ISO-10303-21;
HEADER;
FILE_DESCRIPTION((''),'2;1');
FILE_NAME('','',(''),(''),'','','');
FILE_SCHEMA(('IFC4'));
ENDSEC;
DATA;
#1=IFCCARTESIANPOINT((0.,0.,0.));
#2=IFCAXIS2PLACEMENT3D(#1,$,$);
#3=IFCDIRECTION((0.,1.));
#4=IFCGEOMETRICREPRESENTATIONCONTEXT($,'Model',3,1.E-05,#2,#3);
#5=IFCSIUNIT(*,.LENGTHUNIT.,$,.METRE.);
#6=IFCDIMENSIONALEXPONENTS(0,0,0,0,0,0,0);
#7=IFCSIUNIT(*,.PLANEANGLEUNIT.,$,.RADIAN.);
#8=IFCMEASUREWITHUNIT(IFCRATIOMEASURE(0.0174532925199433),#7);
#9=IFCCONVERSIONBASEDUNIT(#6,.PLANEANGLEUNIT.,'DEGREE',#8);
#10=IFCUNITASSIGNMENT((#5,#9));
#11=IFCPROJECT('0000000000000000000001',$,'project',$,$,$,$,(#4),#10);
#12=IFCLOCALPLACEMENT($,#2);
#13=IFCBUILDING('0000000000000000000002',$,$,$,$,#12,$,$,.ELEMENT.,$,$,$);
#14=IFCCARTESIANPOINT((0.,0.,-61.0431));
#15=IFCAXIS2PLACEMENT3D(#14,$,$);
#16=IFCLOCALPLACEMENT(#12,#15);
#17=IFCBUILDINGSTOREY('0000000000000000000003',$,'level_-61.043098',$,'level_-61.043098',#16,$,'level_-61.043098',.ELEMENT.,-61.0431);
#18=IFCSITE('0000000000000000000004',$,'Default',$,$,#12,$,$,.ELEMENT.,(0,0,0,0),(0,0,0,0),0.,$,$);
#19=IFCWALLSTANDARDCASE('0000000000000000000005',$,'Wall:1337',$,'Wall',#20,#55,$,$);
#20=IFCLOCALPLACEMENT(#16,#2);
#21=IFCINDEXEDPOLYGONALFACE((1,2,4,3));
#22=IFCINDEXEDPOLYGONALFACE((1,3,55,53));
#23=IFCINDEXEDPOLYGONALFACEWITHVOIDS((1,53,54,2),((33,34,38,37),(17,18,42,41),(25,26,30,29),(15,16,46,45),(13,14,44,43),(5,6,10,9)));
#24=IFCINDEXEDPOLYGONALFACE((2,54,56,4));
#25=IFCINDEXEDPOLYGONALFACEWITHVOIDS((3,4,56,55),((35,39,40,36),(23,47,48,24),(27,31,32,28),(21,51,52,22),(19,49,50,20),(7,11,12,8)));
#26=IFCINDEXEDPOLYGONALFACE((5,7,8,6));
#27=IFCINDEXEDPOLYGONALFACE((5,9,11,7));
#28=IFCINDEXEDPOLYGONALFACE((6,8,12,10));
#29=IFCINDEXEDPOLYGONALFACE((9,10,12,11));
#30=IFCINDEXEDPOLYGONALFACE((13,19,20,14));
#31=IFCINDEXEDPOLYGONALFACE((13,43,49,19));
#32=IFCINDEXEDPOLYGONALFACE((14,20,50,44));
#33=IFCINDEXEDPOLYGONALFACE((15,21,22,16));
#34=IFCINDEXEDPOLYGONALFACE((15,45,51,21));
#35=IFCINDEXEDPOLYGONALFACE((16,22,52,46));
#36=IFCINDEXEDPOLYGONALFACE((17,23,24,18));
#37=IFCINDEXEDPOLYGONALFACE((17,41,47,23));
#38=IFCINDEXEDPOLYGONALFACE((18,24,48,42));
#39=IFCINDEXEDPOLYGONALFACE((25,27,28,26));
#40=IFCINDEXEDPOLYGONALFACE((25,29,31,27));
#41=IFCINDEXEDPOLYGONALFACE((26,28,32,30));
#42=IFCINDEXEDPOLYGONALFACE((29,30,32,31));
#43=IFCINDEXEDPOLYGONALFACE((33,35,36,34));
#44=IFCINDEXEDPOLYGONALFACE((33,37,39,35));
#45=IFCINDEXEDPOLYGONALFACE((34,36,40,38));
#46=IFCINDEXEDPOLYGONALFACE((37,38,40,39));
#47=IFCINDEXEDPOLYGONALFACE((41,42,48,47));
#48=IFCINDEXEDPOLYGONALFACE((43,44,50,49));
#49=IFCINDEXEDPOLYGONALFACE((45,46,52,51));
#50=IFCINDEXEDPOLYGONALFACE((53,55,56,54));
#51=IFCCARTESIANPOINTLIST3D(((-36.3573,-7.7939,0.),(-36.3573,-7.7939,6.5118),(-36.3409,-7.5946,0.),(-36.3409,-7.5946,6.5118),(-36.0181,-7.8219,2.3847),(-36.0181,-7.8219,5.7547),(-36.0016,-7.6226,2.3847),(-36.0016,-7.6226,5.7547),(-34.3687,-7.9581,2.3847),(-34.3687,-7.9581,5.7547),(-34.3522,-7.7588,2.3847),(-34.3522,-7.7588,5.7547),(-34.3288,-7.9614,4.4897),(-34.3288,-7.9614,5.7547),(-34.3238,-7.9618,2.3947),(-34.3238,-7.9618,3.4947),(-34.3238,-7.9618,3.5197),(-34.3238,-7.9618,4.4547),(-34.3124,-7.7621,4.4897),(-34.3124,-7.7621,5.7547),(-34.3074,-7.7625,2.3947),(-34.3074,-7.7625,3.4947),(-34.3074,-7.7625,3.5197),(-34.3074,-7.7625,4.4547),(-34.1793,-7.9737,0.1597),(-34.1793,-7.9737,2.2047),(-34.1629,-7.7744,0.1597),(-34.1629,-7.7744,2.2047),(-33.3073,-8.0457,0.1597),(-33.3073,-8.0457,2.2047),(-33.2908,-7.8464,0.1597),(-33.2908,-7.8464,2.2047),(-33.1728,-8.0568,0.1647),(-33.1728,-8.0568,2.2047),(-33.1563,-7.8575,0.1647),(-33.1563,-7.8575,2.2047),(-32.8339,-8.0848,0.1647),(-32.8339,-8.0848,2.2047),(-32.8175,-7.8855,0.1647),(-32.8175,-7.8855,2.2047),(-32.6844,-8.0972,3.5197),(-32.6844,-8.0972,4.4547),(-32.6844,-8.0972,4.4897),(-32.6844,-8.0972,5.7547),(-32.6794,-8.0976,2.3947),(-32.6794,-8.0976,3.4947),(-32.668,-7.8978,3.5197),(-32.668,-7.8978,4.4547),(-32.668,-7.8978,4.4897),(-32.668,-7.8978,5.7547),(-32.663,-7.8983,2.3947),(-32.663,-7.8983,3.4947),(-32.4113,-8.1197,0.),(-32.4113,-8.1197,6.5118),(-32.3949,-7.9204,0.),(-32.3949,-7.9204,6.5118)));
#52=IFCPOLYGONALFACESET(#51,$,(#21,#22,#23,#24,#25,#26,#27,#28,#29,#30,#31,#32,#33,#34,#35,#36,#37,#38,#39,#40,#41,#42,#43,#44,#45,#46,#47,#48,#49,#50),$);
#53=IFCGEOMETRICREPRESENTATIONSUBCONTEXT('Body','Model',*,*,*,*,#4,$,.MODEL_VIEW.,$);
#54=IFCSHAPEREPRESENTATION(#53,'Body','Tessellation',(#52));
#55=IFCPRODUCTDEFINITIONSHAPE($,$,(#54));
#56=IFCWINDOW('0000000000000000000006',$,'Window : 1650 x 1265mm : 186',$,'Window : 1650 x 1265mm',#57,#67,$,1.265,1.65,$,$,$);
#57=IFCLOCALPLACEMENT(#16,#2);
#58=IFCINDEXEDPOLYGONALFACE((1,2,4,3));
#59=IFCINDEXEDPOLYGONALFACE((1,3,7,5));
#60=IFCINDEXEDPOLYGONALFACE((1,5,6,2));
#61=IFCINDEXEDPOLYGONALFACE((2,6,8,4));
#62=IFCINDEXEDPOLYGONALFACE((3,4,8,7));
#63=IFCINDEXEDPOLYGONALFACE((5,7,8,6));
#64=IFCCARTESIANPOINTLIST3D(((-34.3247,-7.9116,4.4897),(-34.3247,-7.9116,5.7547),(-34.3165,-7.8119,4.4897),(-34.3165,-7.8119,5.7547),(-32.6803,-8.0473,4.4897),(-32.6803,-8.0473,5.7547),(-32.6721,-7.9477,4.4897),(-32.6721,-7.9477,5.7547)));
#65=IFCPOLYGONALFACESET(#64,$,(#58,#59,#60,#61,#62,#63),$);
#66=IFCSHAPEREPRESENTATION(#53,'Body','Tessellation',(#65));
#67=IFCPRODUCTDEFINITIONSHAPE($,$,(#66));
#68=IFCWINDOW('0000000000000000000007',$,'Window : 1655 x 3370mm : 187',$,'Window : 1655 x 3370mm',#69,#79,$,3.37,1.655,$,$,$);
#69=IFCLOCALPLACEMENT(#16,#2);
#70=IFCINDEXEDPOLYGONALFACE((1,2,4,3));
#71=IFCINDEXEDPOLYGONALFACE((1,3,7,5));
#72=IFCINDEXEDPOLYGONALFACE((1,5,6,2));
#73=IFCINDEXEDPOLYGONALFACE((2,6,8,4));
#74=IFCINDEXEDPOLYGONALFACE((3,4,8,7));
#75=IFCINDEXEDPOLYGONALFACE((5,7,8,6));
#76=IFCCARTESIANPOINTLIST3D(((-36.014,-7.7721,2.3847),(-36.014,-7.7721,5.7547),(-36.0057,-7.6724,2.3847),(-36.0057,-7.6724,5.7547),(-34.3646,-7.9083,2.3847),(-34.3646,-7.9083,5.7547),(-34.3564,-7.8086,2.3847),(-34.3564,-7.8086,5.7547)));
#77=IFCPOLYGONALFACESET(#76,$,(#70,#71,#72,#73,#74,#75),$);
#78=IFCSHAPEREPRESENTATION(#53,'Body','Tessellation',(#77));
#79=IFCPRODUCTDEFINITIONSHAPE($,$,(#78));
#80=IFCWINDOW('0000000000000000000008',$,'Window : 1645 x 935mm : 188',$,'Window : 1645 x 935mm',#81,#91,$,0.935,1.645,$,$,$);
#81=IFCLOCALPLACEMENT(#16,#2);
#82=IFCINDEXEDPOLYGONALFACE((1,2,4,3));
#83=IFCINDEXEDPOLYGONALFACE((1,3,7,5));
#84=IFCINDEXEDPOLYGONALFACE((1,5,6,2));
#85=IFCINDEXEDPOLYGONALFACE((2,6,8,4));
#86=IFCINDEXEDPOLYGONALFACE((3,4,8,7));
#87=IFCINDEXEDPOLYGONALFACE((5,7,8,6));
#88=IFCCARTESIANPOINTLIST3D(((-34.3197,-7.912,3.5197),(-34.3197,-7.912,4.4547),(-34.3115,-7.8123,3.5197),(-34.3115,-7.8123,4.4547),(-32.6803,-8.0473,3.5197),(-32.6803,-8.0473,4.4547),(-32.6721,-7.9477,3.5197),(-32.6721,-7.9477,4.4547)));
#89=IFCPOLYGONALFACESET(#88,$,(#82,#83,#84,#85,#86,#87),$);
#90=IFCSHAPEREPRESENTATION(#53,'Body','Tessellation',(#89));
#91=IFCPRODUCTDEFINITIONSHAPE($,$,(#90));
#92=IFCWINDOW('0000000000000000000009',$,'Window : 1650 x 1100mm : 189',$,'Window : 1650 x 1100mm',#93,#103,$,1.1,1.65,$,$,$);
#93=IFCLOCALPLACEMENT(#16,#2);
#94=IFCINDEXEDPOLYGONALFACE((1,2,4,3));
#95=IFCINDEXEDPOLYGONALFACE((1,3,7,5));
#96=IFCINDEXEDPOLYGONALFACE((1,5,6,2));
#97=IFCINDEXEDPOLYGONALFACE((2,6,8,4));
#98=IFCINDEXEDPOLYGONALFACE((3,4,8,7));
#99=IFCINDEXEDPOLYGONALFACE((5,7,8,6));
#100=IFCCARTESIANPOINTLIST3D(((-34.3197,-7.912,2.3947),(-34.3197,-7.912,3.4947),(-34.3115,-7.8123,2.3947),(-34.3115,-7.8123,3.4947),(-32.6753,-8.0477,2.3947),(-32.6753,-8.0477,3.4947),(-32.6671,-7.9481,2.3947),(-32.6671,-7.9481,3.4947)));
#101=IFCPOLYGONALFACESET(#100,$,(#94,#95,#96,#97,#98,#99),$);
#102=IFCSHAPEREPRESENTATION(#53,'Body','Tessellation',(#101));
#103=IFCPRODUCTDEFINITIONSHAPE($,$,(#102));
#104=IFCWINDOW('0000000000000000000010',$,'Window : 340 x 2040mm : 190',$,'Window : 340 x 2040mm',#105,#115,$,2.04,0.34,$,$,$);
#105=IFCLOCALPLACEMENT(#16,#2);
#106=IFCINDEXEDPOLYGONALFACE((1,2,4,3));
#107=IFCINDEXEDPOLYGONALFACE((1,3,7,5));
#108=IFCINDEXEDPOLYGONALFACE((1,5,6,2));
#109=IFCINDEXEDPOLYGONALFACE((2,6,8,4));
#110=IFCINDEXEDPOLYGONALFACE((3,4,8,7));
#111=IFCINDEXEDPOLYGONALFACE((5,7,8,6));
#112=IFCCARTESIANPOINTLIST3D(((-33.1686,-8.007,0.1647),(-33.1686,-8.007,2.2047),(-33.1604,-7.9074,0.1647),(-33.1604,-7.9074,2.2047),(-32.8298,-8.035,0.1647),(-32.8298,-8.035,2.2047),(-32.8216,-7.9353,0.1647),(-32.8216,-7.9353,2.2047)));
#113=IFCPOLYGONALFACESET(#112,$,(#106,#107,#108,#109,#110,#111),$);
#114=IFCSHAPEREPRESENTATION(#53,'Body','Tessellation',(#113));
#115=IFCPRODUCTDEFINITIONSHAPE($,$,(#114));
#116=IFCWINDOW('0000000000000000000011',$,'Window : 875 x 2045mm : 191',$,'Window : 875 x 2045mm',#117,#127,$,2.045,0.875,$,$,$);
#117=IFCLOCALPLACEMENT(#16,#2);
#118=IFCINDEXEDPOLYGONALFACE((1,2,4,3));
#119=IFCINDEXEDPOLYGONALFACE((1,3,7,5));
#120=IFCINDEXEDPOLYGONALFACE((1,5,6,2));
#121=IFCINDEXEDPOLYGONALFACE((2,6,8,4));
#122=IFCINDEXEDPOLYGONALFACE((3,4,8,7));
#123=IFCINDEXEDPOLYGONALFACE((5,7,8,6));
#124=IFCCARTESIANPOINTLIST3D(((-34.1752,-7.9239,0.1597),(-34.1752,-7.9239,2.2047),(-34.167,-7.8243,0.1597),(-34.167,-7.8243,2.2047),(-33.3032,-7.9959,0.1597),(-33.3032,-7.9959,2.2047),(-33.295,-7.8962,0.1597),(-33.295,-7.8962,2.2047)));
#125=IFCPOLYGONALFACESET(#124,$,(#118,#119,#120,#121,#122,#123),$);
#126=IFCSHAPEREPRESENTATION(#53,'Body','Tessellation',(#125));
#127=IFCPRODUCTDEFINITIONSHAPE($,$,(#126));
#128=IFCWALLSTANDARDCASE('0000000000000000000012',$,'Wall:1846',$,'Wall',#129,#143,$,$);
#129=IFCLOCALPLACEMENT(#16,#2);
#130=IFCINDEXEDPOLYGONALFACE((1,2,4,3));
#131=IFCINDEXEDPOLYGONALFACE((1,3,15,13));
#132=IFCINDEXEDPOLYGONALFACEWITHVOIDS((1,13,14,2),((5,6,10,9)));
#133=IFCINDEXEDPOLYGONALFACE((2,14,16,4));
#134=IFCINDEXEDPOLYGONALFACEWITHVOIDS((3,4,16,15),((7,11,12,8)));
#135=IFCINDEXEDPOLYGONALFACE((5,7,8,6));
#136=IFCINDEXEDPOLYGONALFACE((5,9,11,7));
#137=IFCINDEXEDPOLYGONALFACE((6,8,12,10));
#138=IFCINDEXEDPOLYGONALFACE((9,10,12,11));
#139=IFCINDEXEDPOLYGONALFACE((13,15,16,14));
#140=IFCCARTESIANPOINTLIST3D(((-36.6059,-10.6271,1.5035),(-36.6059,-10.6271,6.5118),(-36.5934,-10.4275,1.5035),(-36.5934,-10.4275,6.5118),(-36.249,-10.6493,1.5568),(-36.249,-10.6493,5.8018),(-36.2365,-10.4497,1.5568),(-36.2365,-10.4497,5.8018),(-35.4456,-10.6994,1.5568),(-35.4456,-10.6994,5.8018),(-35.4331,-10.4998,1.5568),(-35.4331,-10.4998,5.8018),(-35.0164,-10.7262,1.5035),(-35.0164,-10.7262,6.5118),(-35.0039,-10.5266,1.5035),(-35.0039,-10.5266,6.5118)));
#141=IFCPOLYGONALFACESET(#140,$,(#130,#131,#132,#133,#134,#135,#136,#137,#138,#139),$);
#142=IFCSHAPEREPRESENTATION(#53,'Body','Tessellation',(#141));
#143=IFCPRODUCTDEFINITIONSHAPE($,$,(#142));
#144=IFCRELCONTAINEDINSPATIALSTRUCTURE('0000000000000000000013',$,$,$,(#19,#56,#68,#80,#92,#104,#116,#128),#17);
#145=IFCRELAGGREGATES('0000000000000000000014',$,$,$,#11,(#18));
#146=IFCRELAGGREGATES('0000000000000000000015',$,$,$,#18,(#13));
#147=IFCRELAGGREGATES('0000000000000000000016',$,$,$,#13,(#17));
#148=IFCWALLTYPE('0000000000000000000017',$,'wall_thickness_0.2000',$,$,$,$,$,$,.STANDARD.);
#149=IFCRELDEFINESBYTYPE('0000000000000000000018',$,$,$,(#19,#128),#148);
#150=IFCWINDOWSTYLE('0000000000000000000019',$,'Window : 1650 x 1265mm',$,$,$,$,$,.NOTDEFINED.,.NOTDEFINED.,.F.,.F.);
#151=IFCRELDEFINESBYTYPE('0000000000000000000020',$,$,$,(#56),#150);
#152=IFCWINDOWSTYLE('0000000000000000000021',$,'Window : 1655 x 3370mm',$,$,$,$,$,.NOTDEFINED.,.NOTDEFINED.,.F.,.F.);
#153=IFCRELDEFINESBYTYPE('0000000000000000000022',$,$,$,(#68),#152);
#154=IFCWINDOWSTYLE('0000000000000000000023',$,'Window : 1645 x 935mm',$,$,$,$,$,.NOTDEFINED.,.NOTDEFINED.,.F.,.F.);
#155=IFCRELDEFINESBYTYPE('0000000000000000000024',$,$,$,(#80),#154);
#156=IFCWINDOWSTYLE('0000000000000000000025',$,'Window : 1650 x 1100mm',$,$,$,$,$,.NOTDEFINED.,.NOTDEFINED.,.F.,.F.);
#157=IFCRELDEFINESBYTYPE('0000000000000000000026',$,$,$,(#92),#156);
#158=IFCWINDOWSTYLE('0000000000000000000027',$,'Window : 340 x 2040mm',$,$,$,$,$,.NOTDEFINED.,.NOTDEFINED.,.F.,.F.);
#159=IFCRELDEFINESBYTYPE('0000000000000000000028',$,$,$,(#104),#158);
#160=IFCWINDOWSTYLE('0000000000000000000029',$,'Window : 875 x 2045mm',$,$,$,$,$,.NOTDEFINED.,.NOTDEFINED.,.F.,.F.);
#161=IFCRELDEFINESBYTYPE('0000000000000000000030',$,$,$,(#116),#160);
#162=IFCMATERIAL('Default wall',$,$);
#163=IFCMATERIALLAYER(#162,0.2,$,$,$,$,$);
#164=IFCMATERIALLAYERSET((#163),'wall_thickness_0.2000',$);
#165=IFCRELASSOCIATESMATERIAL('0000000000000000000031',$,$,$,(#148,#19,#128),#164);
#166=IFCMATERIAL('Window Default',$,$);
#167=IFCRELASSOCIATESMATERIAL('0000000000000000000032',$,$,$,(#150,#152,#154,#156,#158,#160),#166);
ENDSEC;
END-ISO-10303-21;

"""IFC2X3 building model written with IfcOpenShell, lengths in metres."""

from ifc_helpers import new_model, entity, si_unit, converted_unit, direction, frame, frame_2d, origin, origin_2d_with_axis, place, context, subcontext, project, spatial, polyline, rectangle, outline, extrude, source, transform, mapped, material, layer, layer_set, layer_usage, type_object, type_shapes, element, fill, save


model = new_model("IFC2X3")

# Units and contexts
model_context = context("Model", 3, precision=1e-05, world=origin(), true_north=direction((0.0, 1.0)))
body_context = subcontext(model_context, "Body", "Model", "MODEL_VIEW")
ifc_project = project(units=[si_unit("LENGTHUNIT", "METRE"), converted_unit("PLANEANGLEUNIT", "DEGREE", entity("IfcRatioMeasure", 0.0174532925199433), si_unit("PLANEANGLEUNIT", "RADIAN"), dimensions=[0, 0, 0, 0, 0, 0, 0])], contexts=[model_context])

# Site, building, storey
placement_1 = place(None, origin())
site = spatial("IfcSite", under=ifc_project, at=placement_1, Name="Default", CompositionType="ELEMENT", RefLatitude=(0, 0, 0, 0), RefLongitude=(0, 0, 0, 0), RefElevation=0.0)
building = spatial("IfcBuilding", under=site, at=placement_1, CompositionType="ELEMENT")
storey_placement = place(placement_1, frame((0.0, 0.0, -61.0431)))
storey = spatial("IfcBuildingStorey", under=building, at=storey_placement, Name="level_-61.043098", ObjectType="level_-61.043098", LongName="level_-61.043098", CompositionType="ELEMENT", Elevation=-61.0431)

# Shared definitions
ifc_material_1 = material(Name="Default wall")
ifc_layer = layer(ifc_material_1, 0.2)
ifc_layer_set = layer_set([ifc_layer], Name="wall_thickness_0.2000")
ifc_layer_usage = layer_usage(ifc_layer_set, "AXIS2", "POSITIVE", -0.1)
wall_type = type_object("IfcWallType", Name="wall_thickness_0.2000", PredefinedType="STANDARD", material=ifc_layer_set)

# Shared definitions
ifc_material_2 = material(Name="Window Default")

# Wall, openings, windows
wall_1_placement = place(storey_placement, frame((-32.4031, -8.0201, 0.0), z_axis=(0.0, 0.0, 1.0), x_axis=(-0.996609, 0.082281, 0.0)))
wall_1 = element("IfcWallStandardCase", 1, at=wall_1_placement, inside=storey, type_object=wall_type, material=ifc_layer_usage, Name="Wall:1337", ObjectType="Wall", context=body_context, shape_type="SweptSolid", body=[
    extrude(outline(polyline([(3.9594, -0.1), (3.9594, 0.1), (0.0, 0.1), (0.0, -0.1), (3.9594, -0.1)])), origin(), (0.0, 0.0, 1.0), 6.5118),
])
opening_1_placement = place(wall_1_placement, frame((0.274, -0.1, 4.4897)))
opening_1 = element("IfcOpeningElement", 2, at=opening_1_placement, cuts=wall_1, ObjectType="Opening", context=body_context, shape_type="SweptSolid", body=[
    extrude(rectangle(XDim=1.65, YDim=1.265, at=frame_2d((0.6325, 0.825), x_axis=(0.0, 1.0))), frame((0.0, 0.0, 0.0), z_axis=(0.0, 1.0, 0.0), x_axis=(0.0, 0.0, 1.0)), (0.0, 0.0, 1.0), 0.2),
])
opening_2_placement = place(wall_1_placement, frame((1.964, -0.1, 2.3847)))
opening_2 = element("IfcOpeningElement", 3, at=opening_2_placement, cuts=wall_1, ObjectType="Opening", context=body_context, shape_type="SweptSolid", body=[
    extrude(rectangle(XDim=1.655, YDim=3.37, at=frame_2d((1.685, 0.8275), x_axis=(0.0, 1.0))), frame((0.0, 0.0, 0.0), z_axis=(0.0, 1.0, 0.0), x_axis=(0.0, 0.0, 1.0)), (0.0, 0.0, 1.0), 0.2),
])
opening_3_placement = place(wall_1_placement, frame((0.274, -0.1, 3.5197)))
opening_3 = element("IfcOpeningElement", 4, at=opening_3_placement, cuts=wall_1, ObjectType="Opening", context=body_context, shape_type="SweptSolid", body=[
    extrude(rectangle(XDim=1.645, YDim=0.935, at=frame_2d((0.4675, 0.8225), x_axis=(0.0, 1.0))), frame((0.0, 0.0, 0.0), z_axis=(0.0, 1.0, 0.0), x_axis=(0.0, 0.0, 1.0)), (0.0, 0.0, 1.0), 0.2),
])
opening_4_placement = place(wall_1_placement, frame((0.269, -0.1, 2.3947)))
opening_4 = element("IfcOpeningElement", 5, at=opening_4_placement, cuts=wall_1, ObjectType="Opening", context=body_context, shape_type="SweptSolid", body=[
    extrude(rectangle(XDim=1.65, YDim=1.1, at=frame_2d((0.55, 0.825), x_axis=(0.0, 1.0))), frame((0.0, 0.0, 0.0), z_axis=(0.0, 1.0, 0.0), x_axis=(0.0, 0.0, 1.0)), (0.0, 0.0, 1.0), 0.2),
])
opening_5_placement = place(wall_1_placement, frame((0.424, -0.1, 0.1647)))
opening_5 = element("IfcOpeningElement", 6, at=opening_5_placement, cuts=wall_1, ObjectType="Opening", context=body_context, shape_type="SweptSolid", body=[
    extrude(rectangle(XDim=0.34, YDim=2.04, at=frame_2d((1.02, 0.17), x_axis=(0.0, 1.0))), frame((0.0, 0.0, 0.0), z_axis=(0.0, 1.0, 0.0), x_axis=(0.0, 0.0, 1.0)), (0.0, 0.0, 1.0), 0.2),
])
opening_6_placement = place(wall_1_placement, frame((0.899, -0.1, 0.1597)))
opening_6 = element("IfcOpeningElement", 7, at=opening_6_placement, cuts=wall_1, ObjectType="Opening", context=body_context, shape_type="SweptSolid", body=[
    extrude(rectangle(XDim=0.875, YDim=2.045, at=frame_2d((1.0225, 0.4375), x_axis=(0.0, 1.0))), frame((0.0, 0.0, 0.0), z_axis=(0.0, 1.0, 0.0), x_axis=(0.0, 0.0, 1.0)), (0.0, 0.0, 1.0), 0.2),
])
window_style_1 = type_object("IfcWindowStyle", Name="Window : 1650 x 1265mm", ConstructionType="NOTDEFINED", OperationType="NOTDEFINED", ParameterTakesPrecedence=False, Sizeable=False, material=ifc_material_2)
shared_shape_1 = source(origin(), body_context, "Body", "SweptSolid", [
    extrude(rectangle(XDim=0.1, YDim=1.65, at=origin_2d_with_axis()), frame((0.825, 0.1, 0.0), z_axis=(0.0, 0.0, 1.0), x_axis=(0.0, 1.0, 0.0)), (0.0, 0.0, 1.0), 1.265),
])
type_shapes(window_style_1, [shared_shape_1])
window_1_placement = place(opening_1_placement, origin())
window_1 = element("IfcWindow", 8, at=window_1_placement, inside=storey, type_object=window_style_1, Name="Window : 1650 x 1265mm : 186", ObjectType="Window : 1650 x 1265mm", OverallHeight=1.265, OverallWidth=1.65, context=body_context, shape_type="MappedRepresentation", body=[
    mapped(shared_shape_1, transform((0.0, 0.0, 0.0), scale=1.0)),
])
fill(opening_1, window_1)
window_style_2 = type_object("IfcWindowStyle", Name="Window : 1655 x 3370mm", ConstructionType="NOTDEFINED", OperationType="NOTDEFINED", ParameterTakesPrecedence=False, Sizeable=False, material=ifc_material_2)
shared_shape_2 = source(origin(), body_context, "Body", "SweptSolid", [
    extrude(rectangle(XDim=0.1, YDim=1.655, at=origin_2d_with_axis()), frame((0.8275, 0.1, 0.0), z_axis=(0.0, 0.0, 1.0), x_axis=(0.0, 1.0, 0.0)), (0.0, 0.0, 1.0), 3.37),
])
type_shapes(window_style_2, [shared_shape_2])
window_2_placement = place(opening_2_placement, origin())
window_2 = element("IfcWindow", 9, at=window_2_placement, inside=storey, type_object=window_style_2, Name="Window : 1655 x 3370mm : 187", ObjectType="Window : 1655 x 3370mm", OverallHeight=3.37, OverallWidth=1.655, context=body_context, shape_type="MappedRepresentation", body=[
    mapped(shared_shape_2, transform((0.0, 0.0, 0.0), scale=1.0)),
])
fill(opening_2, window_2)
window_style_3 = type_object("IfcWindowStyle", Name="Window : 1645 x 935mm", ConstructionType="NOTDEFINED", OperationType="NOTDEFINED", ParameterTakesPrecedence=False, Sizeable=False, material=ifc_material_2)
shared_shape_3 = source(origin(), body_context, "Body", "SweptSolid", [
    extrude(rectangle(XDim=0.1, YDim=1.645, at=origin_2d_with_axis()), frame((0.8225, 0.1, 0.0), z_axis=(0.0, 0.0, 1.0), x_axis=(0.0, 1.0, 0.0)), (0.0, 0.0, 1.0), 0.935),
])
type_shapes(window_style_3, [shared_shape_3])
window_3_placement = place(opening_3_placement, origin())
window_3 = element("IfcWindow", 10, at=window_3_placement, inside=storey, type_object=window_style_3, Name="Window : 1645 x 935mm : 188", ObjectType="Window : 1645 x 935mm", OverallHeight=0.935, OverallWidth=1.645, context=body_context, shape_type="MappedRepresentation", body=[
    mapped(shared_shape_3, transform((0.0, 0.0, 0.0), scale=1.0)),
])
fill(opening_3, window_3)
window_style_4 = type_object("IfcWindowStyle", Name="Window : 1650 x 1100mm", ConstructionType="NOTDEFINED", OperationType="NOTDEFINED", ParameterTakesPrecedence=False, Sizeable=False, material=ifc_material_2)
shared_shape_4 = source(origin(), body_context, "Body", "SweptSolid", [
    extrude(rectangle(XDim=0.1, YDim=1.65, at=origin_2d_with_axis()), frame((0.825, 0.1, 0.0), z_axis=(0.0, 0.0, 1.0), x_axis=(0.0, 1.0, 0.0)), (0.0, 0.0, 1.0), 1.1),
])
type_shapes(window_style_4, [shared_shape_4])
window_4_placement = place(opening_4_placement, origin())
window_4 = element("IfcWindow", 11, at=window_4_placement, inside=storey, type_object=window_style_4, Name="Window : 1650 x 1100mm : 189", ObjectType="Window : 1650 x 1100mm", OverallHeight=1.1, OverallWidth=1.65, context=body_context, shape_type="MappedRepresentation", body=[
    mapped(shared_shape_4, transform((0.0, 0.0, 0.0), scale=1.0)),
])
fill(opening_4, window_4)
window_style_5 = type_object("IfcWindowStyle", Name="Window : 340 x 2040mm", ConstructionType="NOTDEFINED", OperationType="NOTDEFINED", ParameterTakesPrecedence=False, Sizeable=False, material=ifc_material_2)
shared_shape_5 = source(origin(), body_context, "Body", "SweptSolid", [
    extrude(rectangle(XDim=0.1, YDim=0.34, at=origin_2d_with_axis()), frame((0.17, 0.1, 0.0), z_axis=(0.0, 0.0, 1.0), x_axis=(0.0, 1.0, 0.0)), (0.0, 0.0, 1.0), 2.04),
])
type_shapes(window_style_5, [shared_shape_5])
window_5_placement = place(opening_5_placement, origin())
window_5 = element("IfcWindow", 12, at=window_5_placement, inside=storey, type_object=window_style_5, Name="Window : 340 x 2040mm : 190", ObjectType="Window : 340 x 2040mm", OverallHeight=2.04, OverallWidth=0.34, context=body_context, shape_type="MappedRepresentation", body=[
    mapped(shared_shape_5, transform((0.0, 0.0, 0.0), scale=1.0)),
])
fill(opening_5, window_5)
window_style_6 = type_object("IfcWindowStyle", Name="Window : 875 x 2045mm", ConstructionType="NOTDEFINED", OperationType="NOTDEFINED", ParameterTakesPrecedence=False, Sizeable=False, material=ifc_material_2)
shared_shape_6 = source(origin(), body_context, "Body", "SweptSolid", [
    extrude(rectangle(XDim=0.1, YDim=0.875, at=origin_2d_with_axis()), frame((0.4375, 0.1, 0.0), z_axis=(0.0, 0.0, 1.0), x_axis=(0.0, 1.0, 0.0)), (0.0, 0.0, 1.0), 2.045),
])
type_shapes(window_style_6, [shared_shape_6])
window_6_placement = place(opening_6_placement, origin())
window_6 = element("IfcWindow", 13, at=window_6_placement, inside=storey, type_object=window_style_6, Name="Window : 875 x 2045mm : 191", ObjectType="Window : 875 x 2045mm", OverallHeight=2.045, OverallWidth=0.875, context=body_context, shape_type="MappedRepresentation", body=[
    mapped(shared_shape_6, transform((0.0, 0.0, 0.0), scale=1.0)),
])
fill(opening_6, window_6)

# Wall, opening
placement_2 = place(placement_1, frame((0.0, 0.0, -59.5396)))
wall_2_placement = place(placement_2, frame((-35.0102, -10.6264, 0.0), z_axis=(0.0, 0.0, 1.0), x_axis=(-0.998063, 0.062212, 0.0)))
wall_2 = element("IfcWallStandardCase", 14, at=wall_2_placement, inside=storey, type_object=wall_type, material=ifc_layer_usage, Name="Wall:1846", ObjectType="Wall", context=body_context, shape_type="SweptSolid", body=[
    extrude(outline(polyline([(1.5926, -0.1), (1.5926, 0.1), (0.0, 0.1), (0.0, -0.1), (1.5926, -0.1)])), origin(), (0.0, 0.0, 1.0), 5.0083),
])
opening_7_placement = place(wall_2_placement, frame((0.43, -0.1, 0.0533)))
element("IfcOpeningElement", 15, at=opening_7_placement, cuts=wall_2, ObjectType="Opening", context=body_context, shape_type="SweptSolid", body=[
    extrude(rectangle(XDim=0.805, YDim=4.245, at=frame_2d((2.1225, 0.4025), x_axis=(0.0, 1.0))), frame((0.0, 0.0, 0.0), z_axis=(0.0, 1.0, 0.0), x_axis=(0.0, 0.0, 1.0)), (0.0, 0.0, 1.0), 0.2),
])

save(model, "model.ifc")
